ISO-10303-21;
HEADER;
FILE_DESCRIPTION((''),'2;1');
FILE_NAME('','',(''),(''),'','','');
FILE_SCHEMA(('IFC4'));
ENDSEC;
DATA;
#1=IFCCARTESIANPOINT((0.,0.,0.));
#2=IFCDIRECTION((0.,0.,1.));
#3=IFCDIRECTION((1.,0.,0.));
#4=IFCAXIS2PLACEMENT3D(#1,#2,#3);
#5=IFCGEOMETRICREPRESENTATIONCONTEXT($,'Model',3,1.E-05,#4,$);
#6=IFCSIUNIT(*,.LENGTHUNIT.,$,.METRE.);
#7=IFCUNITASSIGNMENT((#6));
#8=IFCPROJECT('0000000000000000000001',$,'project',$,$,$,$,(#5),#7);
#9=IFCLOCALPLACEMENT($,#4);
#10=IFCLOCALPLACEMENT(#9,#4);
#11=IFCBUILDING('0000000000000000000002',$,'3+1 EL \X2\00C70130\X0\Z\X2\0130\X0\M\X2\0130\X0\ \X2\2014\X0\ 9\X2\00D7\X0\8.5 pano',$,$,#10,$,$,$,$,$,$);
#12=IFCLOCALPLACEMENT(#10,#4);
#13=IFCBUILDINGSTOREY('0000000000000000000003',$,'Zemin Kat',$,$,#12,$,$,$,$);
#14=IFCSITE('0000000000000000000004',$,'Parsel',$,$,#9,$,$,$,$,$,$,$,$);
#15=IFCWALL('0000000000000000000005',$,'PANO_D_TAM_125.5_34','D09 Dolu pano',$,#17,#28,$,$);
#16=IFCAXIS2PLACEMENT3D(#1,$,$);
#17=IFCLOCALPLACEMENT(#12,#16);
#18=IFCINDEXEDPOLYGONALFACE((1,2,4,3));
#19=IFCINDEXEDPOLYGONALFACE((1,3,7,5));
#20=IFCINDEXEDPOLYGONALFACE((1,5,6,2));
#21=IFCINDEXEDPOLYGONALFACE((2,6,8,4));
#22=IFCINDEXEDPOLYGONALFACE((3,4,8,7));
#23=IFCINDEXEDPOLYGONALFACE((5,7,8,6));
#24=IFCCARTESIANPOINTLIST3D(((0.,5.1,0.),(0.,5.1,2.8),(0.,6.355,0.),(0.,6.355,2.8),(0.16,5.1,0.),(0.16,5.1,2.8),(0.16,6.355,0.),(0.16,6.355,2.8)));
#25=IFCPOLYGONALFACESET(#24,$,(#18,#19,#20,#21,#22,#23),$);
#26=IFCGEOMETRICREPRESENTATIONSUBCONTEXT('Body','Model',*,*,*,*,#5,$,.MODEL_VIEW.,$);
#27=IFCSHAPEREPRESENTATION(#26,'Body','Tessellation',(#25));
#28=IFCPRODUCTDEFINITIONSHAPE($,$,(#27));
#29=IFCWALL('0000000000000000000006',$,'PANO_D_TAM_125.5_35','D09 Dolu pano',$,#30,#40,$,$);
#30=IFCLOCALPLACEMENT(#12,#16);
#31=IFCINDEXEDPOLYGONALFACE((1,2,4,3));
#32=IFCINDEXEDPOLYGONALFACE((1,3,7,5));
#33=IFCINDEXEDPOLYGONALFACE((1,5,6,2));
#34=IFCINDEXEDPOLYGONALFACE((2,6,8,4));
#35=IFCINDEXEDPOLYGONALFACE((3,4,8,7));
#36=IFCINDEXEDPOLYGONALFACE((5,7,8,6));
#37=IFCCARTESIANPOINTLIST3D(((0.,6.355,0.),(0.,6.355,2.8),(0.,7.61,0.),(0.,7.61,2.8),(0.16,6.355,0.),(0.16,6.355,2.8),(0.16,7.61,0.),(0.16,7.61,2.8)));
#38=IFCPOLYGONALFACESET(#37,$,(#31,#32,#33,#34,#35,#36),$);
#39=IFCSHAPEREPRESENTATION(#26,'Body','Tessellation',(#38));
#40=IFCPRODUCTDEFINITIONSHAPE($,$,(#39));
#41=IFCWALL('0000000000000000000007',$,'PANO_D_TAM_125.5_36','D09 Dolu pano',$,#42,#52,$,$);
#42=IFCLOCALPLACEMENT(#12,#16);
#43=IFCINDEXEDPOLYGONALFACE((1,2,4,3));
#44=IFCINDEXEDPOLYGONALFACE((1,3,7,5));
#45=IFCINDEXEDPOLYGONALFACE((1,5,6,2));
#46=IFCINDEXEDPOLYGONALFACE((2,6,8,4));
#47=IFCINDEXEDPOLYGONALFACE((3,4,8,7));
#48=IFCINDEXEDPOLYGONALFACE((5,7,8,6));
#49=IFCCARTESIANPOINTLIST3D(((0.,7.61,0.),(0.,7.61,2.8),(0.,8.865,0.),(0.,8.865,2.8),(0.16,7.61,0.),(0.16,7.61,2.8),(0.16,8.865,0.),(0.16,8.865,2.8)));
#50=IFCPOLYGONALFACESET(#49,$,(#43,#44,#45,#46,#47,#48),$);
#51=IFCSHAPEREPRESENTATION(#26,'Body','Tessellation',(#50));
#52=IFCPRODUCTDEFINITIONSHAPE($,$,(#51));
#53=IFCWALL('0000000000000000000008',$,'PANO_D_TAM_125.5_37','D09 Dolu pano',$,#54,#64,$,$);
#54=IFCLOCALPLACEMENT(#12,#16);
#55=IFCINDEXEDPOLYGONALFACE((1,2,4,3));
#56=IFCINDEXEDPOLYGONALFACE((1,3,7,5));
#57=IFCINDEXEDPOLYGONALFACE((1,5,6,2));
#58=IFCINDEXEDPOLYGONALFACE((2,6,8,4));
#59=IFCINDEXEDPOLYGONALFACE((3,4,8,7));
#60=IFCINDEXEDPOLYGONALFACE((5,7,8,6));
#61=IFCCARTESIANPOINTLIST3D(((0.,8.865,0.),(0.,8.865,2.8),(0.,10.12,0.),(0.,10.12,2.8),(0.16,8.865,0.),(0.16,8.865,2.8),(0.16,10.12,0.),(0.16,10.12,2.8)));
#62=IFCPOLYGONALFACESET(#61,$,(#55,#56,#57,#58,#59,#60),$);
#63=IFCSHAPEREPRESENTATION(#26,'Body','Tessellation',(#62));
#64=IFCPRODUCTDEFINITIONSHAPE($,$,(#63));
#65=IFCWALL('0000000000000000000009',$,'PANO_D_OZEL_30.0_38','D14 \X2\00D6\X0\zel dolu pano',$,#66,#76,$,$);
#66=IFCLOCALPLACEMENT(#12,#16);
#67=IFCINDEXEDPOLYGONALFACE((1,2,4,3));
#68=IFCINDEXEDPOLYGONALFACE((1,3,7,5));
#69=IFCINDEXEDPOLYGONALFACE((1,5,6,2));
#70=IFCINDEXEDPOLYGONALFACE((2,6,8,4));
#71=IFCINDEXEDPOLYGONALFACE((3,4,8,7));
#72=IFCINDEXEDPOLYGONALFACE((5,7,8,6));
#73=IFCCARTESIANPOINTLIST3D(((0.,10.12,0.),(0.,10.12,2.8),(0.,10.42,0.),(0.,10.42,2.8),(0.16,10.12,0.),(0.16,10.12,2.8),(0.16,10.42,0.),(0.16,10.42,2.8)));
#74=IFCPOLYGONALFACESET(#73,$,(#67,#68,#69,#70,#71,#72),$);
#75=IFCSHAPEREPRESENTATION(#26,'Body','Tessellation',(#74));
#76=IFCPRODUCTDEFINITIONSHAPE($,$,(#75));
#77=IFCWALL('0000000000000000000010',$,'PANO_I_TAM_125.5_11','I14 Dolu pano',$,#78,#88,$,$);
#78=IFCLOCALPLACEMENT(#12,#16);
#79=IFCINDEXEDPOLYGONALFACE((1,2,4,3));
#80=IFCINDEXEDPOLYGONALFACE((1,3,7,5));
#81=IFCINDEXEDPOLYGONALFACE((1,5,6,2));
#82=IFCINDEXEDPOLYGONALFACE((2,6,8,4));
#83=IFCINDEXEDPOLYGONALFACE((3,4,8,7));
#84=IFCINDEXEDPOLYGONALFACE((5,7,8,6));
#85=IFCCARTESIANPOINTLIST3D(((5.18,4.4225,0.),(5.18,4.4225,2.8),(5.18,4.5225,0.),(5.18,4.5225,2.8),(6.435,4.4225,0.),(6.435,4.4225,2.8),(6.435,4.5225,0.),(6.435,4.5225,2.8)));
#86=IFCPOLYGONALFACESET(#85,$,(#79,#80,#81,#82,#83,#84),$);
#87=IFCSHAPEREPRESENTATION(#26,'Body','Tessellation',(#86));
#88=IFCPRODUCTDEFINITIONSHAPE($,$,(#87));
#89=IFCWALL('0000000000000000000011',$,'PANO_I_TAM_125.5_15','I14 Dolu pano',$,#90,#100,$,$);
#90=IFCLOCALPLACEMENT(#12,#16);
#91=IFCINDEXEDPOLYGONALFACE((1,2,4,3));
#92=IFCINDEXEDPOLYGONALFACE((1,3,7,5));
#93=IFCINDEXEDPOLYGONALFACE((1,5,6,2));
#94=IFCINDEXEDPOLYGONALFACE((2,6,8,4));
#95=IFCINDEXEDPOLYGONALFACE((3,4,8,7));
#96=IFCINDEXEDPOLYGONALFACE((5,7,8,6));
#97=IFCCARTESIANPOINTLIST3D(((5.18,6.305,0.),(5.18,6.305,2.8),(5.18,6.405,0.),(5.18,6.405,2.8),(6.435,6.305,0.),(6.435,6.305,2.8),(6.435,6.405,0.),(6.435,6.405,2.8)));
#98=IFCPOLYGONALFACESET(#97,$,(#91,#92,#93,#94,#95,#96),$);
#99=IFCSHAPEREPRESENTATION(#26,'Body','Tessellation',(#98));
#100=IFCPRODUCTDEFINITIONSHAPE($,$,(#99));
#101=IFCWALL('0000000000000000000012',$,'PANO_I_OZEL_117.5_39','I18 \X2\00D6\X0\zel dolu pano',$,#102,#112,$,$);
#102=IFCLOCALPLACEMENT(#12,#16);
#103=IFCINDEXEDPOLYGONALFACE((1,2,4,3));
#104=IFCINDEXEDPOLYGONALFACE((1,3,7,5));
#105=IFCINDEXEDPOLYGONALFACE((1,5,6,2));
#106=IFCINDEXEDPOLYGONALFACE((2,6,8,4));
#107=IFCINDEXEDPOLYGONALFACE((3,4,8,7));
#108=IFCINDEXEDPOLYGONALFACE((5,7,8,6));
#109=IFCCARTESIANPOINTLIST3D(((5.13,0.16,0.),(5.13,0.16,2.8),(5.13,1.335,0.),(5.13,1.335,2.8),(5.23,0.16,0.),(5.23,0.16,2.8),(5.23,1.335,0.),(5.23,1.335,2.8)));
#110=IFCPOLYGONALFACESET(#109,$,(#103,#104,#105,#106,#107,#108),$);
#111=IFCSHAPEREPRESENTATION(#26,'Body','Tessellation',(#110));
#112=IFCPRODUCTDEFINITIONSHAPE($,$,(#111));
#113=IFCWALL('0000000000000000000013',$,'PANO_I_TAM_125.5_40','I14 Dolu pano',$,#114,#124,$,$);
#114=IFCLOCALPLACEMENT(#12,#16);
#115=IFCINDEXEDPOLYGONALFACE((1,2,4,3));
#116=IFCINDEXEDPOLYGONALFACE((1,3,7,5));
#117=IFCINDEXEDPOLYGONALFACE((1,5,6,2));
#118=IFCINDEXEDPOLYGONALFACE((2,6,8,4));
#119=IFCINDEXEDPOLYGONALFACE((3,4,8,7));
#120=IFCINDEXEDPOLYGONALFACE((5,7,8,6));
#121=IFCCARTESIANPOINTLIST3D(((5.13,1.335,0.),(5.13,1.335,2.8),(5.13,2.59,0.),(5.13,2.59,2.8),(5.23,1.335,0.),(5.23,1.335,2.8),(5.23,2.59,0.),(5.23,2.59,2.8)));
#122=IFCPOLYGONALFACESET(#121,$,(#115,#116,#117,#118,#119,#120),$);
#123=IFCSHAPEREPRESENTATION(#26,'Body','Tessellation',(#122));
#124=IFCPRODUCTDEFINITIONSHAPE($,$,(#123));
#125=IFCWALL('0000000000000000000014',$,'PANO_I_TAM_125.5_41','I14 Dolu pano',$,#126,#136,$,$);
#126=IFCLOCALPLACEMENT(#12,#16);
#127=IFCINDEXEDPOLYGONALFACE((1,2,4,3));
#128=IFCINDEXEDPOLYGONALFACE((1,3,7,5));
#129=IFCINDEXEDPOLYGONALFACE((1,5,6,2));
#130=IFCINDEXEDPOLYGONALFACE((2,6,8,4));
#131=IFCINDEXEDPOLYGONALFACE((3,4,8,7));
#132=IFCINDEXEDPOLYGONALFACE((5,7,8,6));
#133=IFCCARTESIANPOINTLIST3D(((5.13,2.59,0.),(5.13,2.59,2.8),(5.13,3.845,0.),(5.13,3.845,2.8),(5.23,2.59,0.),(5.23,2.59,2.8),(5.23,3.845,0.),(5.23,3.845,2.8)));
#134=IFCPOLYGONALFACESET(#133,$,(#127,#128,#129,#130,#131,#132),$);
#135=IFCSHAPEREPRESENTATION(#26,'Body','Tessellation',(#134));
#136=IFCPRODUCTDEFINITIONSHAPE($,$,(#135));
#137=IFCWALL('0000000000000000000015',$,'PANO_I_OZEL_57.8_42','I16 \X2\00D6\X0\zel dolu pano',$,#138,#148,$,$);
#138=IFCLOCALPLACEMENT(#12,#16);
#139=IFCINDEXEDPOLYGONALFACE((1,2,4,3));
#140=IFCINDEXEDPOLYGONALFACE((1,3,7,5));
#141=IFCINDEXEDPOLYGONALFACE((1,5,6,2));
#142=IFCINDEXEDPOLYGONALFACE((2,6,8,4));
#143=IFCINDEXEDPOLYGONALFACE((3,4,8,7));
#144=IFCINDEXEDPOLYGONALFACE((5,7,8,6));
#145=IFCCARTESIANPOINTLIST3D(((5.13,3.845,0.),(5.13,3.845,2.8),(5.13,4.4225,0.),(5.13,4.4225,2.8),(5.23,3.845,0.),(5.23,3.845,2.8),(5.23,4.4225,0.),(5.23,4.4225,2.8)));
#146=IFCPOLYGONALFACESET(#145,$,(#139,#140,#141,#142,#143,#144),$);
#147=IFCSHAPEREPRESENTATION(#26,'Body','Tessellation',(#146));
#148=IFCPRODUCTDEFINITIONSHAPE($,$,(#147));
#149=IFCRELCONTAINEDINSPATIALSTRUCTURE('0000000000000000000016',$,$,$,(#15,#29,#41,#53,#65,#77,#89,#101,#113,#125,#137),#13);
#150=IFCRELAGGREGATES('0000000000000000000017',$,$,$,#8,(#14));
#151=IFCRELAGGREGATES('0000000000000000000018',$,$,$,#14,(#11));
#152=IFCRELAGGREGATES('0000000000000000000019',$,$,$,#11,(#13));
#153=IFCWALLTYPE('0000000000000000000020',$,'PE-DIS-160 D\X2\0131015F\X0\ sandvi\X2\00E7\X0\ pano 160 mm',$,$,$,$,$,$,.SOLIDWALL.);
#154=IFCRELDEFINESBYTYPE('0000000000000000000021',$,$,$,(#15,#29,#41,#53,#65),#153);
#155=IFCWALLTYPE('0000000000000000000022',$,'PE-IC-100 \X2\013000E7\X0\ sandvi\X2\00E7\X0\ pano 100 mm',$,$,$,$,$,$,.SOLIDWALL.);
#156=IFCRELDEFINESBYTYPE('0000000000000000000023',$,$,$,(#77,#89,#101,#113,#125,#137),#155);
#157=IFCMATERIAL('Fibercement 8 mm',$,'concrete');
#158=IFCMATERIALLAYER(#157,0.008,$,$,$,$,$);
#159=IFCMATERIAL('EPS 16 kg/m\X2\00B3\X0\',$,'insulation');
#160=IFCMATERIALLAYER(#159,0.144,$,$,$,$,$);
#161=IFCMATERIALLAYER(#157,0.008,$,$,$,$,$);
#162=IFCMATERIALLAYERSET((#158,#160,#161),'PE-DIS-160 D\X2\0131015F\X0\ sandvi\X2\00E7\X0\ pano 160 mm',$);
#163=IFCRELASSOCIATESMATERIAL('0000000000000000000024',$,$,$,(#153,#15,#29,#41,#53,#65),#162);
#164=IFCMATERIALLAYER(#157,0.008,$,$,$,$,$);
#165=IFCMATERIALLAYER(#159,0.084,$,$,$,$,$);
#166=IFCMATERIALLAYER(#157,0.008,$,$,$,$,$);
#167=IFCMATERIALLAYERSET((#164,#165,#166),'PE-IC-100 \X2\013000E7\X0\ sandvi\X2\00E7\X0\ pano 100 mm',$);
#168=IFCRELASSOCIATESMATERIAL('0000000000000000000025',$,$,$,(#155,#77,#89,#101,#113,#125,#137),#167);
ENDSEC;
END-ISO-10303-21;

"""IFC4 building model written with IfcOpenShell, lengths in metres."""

from ifc_helpers import new_model, si_unit, frame, origin_with_axes, place, context, subcontext, project, spatial, line, indexed_curve, outline, extrude, material, layer, layer_set, layer_usage, type_object, element, save


model = new_model("IFC4")

# Units and contexts
model_context = context("Model", 3, precision=1e-05, world=origin_with_axes())
body_context = subcontext(model_context, "Body", "Model", "MODEL_VIEW")
ifc_project = project(units=[si_unit("LENGTHUNIT", "METRE")], contexts=[model_context])

# Site, building, storey
site_placement = place(None, origin_with_axes())
site = spatial("IfcSite", under=ifc_project, at=site_placement, Name="Parsel")
building_placement = place(site_placement, origin_with_axes())
building = spatial("IfcBuilding", under=site, at=building_placement, Name="3+1 EL ÇİZİMİ — 9×8.5 pano")
storey_placement = place(building_placement, origin_with_axes())
storey = spatial("IfcBuildingStorey", under=building, at=storey_placement, Name="Zemin Kat")

# Shared definitions
ifc_material_1 = material(Name="Fibercement 8 mm", Category="concrete")
ifc_layer_1 = layer(ifc_material_1, 0.008)
ifc_material_2 = material(Name="EPS 16 kg/m³", Category="insulation")
ifc_layer_2 = layer(ifc_material_2, 0.144)
ifc_layer_3 = layer(ifc_material_1, 0.008)
ifc_layer_set_1 = layer_set([ifc_layer_1, ifc_layer_2, ifc_layer_3], Name="PE-DIS-160 Dış sandviç pano 160 mm")
wall_type_1 = type_object("IfcWallType", Name="PE-DIS-160 Dış sandviç pano 160 mm", PredefinedType="SOLIDWALL", material=ifc_layer_set_1)

# Walls
ifc_layer_usage_1 = layer_usage(ifc_layer_set_1, "AXIS2", "POSITIVE", 0.0)
wall_1_placement = place(storey_placement, frame((0.16, 5.1, 0.0), z_axis=(0.0, 0.0, 1.0), x_axis=(0.0, 1.0, 0.0)))
element("IfcWall", 1, at=wall_1_placement, inside=storey, type_object=wall_type_1, material=ifc_layer_usage_1, Name="PANO_D_TAM_125.5_34", Description="D09 Dolu pano", context=body_context, shape_type="SweptSolid", body=[
    extrude(outline(indexed_curve([(0.0, 0.0), (1.255, 0.0), (1.255, 0.16), (0.0, 0.16)], segments=[line(1, 2, 3, 4, 1)])), origin_with_axes(), (0.0, 0.0, 1.0), 2.8),
])
ifc_layer_usage_2 = layer_usage(ifc_layer_set_1, "AXIS2", "POSITIVE", 0.0)
wall_2_placement = place(storey_placement, frame((0.16, 6.355, 0.0), z_axis=(0.0, 0.0, 1.0), x_axis=(0.0, 1.0, 0.0)))
element("IfcWall", 2, at=wall_2_placement, inside=storey, type_object=wall_type_1, material=ifc_layer_usage_2, Name="PANO_D_TAM_125.5_35", Description="D09 Dolu pano", context=body_context, shape_type="SweptSolid", body=[
    extrude(outline(indexed_curve([(0.0, 0.0), (1.255, 0.0), (1.255, 0.16), (0.0, 0.16)], segments=[line(1, 2, 3, 4, 1)])), origin_with_axes(), (0.0, 0.0, 1.0), 2.8),
])
ifc_layer_usage_3 = layer_usage(ifc_layer_set_1, "AXIS2", "POSITIVE", 0.0)
wall_3_placement = place(storey_placement, frame((0.16, 7.61, 0.0), z_axis=(0.0, 0.0, 1.0), x_axis=(0.0, 1.0, 0.0)))
element("IfcWall", 3, at=wall_3_placement, inside=storey, type_object=wall_type_1, material=ifc_layer_usage_3, Name="PANO_D_TAM_125.5_36", Description="D09 Dolu pano", context=body_context, shape_type="SweptSolid", body=[
    extrude(outline(indexed_curve([(0.0, 0.0), (1.255, 0.0), (1.255, 0.16), (0.0, 0.16)], segments=[line(1, 2, 3, 4, 1)])), origin_with_axes(), (0.0, 0.0, 1.0), 2.8),
])
ifc_layer_usage_4 = layer_usage(ifc_layer_set_1, "AXIS2", "POSITIVE", 0.0)
wall_4_placement = place(storey_placement, frame((0.16, 8.865, 0.0), z_axis=(0.0, 0.0, 1.0), x_axis=(0.0, 1.0, 0.0)))
element("IfcWall", 4, at=wall_4_placement, inside=storey, type_object=wall_type_1, material=ifc_layer_usage_4, Name="PANO_D_TAM_125.5_37", Description="D09 Dolu pano", context=body_context, shape_type="SweptSolid", body=[
    extrude(outline(indexed_curve([(0.0, 0.0), (1.255, 0.0), (1.255, 0.16), (0.0, 0.16)], segments=[line(1, 2, 3, 4, 1)])), origin_with_axes(), (0.0, 0.0, 1.0), 2.8),
])
ifc_layer_usage_5 = layer_usage(ifc_layer_set_1, "AXIS2", "POSITIVE", 0.0)
wall_5_placement = place(storey_placement, frame((0.16, 10.12, 0.0), z_axis=(0.0, 0.0, 1.0), x_axis=(0.0, 1.0, 0.0)))
element("IfcWall", 5, at=wall_5_placement, inside=storey, type_object=wall_type_1, material=ifc_layer_usage_5, Name="PANO_D_OZEL_30.0_38", Description="D14 Özel dolu pano", context=body_context, shape_type="SweptSolid", body=[
    extrude(outline(indexed_curve([(0.0, 0.0), (0.3, 0.0), (0.3, 0.16), (0.0, 0.16)], segments=[line(1, 2, 3, 4, 1)])), origin_with_axes(), (0.0, 0.0, 1.0), 2.8),
])
ifc_layer_4 = layer(ifc_material_1, 0.008)
ifc_layer_5 = layer(ifc_material_2, 0.084)
ifc_layer_6 = layer(ifc_material_1, 0.008)
ifc_layer_set_2 = layer_set([ifc_layer_4, ifc_layer_5, ifc_layer_6], Name="PE-IC-100 İç sandviç pano 100 mm")
ifc_layer_usage_6 = layer_usage(ifc_layer_set_2, "AXIS2", "POSITIVE", 0.0)
wall_type_2 = type_object("IfcWallType", Name="PE-IC-100 İç sandviç pano 100 mm", PredefinedType="SOLIDWALL", material=ifc_layer_set_2)
wall_6_placement = place(storey_placement, frame((5.18, 4.4225, 0.0), z_axis=(0.0, 0.0, 1.0), x_axis=(1.0, 0.0, 0.0)))
element("IfcWall", 6, at=wall_6_placement, inside=storey, type_object=wall_type_2, material=ifc_layer_usage_6, Name="PANO_I_TAM_125.5_11", Description="I14 Dolu pano", context=body_context, shape_type="SweptSolid", body=[
    extrude(outline(indexed_curve([(0.0, 0.0), (1.255, 0.0), (1.255, 0.1), (0.0, 0.1)], segments=[line(1, 2, 3, 4, 1)])), origin_with_axes(), (0.0, 0.0, 1.0), 2.8),
])
ifc_layer_usage_7 = layer_usage(ifc_layer_set_2, "AXIS2", "POSITIVE", 0.0)
wall_7_placement = place(storey_placement, frame((5.18, 6.305, 0.0), z_axis=(0.0, 0.0, 1.0), x_axis=(1.0, 0.0, 0.0)))
element("IfcWall", 7, at=wall_7_placement, inside=storey, type_object=wall_type_2, material=ifc_layer_usage_7, Name="PANO_I_TAM_125.5_15", Description="I14 Dolu pano", context=body_context, shape_type="SweptSolid", body=[
    extrude(outline(indexed_curve([(0.0, 0.0), (1.255, 0.0), (1.255, 0.1), (0.0, 0.1)], segments=[line(1, 2, 3, 4, 1)])), origin_with_axes(), (0.0, 0.0, 1.0), 2.8),
])
ifc_layer_usage_8 = layer_usage(ifc_layer_set_2, "AXIS2", "POSITIVE", 0.0)
wall_8_placement = place(storey_placement, frame((5.23, 0.16, 0.0), z_axis=(0.0, 0.0, 1.0), x_axis=(0.0, 1.0, 0.0)))
element("IfcWall", 8, at=wall_8_placement, inside=storey, type_object=wall_type_2, material=ifc_layer_usage_8, Name="PANO_I_OZEL_117.5_39", Description="I18 Özel dolu pano", context=body_context, shape_type="SweptSolid", body=[
    extrude(outline(indexed_curve([(0.0, 0.0), (1.175, 0.0), (1.175, 0.1), (0.0, 0.1)], segments=[line(1, 2, 3, 4, 1)])), origin_with_axes(), (0.0, 0.0, 1.0), 2.8),
])
ifc_layer_usage_9 = layer_usage(ifc_layer_set_2, "AXIS2", "POSITIVE", 0.0)
wall_9_placement = place(storey_placement, frame((5.23, 1.335, 0.0), z_axis=(0.0, 0.0, 1.0), x_axis=(0.0, 1.0, 0.0)))
element("IfcWall", 9, at=wall_9_placement, inside=storey, type_object=wall_type_2, material=ifc_layer_usage_9, Name="PANO_I_TAM_125.5_40", Description="I14 Dolu pano", context=body_context, shape_type="SweptSolid", body=[
    extrude(outline(indexed_curve([(0.0, 0.0), (1.255, 0.0), (1.255, 0.1), (0.0, 0.1)], segments=[line(1, 2, 3, 4, 1)])), origin_with_axes(), (0.0, 0.0, 1.0), 2.8),
])
ifc_layer_usage_10 = layer_usage(ifc_layer_set_2, "AXIS2", "POSITIVE", 0.0)
wall_10_placement = place(storey_placement, frame((5.23, 2.59, 0.0), z_axis=(0.0, 0.0, 1.0), x_axis=(0.0, 1.0, 0.0)))
element("IfcWall", 10, at=wall_10_placement, inside=storey, type_object=wall_type_2, material=ifc_layer_usage_10, Name="PANO_I_TAM_125.5_41", Description="I14 Dolu pano", context=body_context, shape_type="SweptSolid", body=[
    extrude(outline(indexed_curve([(0.0, 0.0), (1.255, 0.0), (1.255, 0.1), (0.0, 0.1)], segments=[line(1, 2, 3, 4, 1)])), origin_with_axes(), (0.0, 0.0, 1.0), 2.8),
])
ifc_layer_usage_11 = layer_usage(ifc_layer_set_2, "AXIS2", "POSITIVE", 0.0)
wall_11_placement = place(storey_placement, frame((5.23, 3.845, 0.0), z_axis=(0.0, 0.0, 1.0), x_axis=(0.0, 1.0, 0.0)))
element("IfcWall", 11, at=wall_11_placement, inside=storey, type_object=wall_type_2, material=ifc_layer_usage_11, Name="PANO_I_OZEL_57.8_42", Description="I16 Özel dolu pano", context=body_context, shape_type="SweptSolid", body=[
    extrude(outline(indexed_curve([(0.0, 0.0), (0.5775, 0.0), (0.5775, 0.1), (0.0, 0.1)], segments=[line(1, 2, 3, 4, 1)])), origin_with_axes(), (0.0, 0.0, 1.0), 2.8),
])

save(model, "model.ifc")
